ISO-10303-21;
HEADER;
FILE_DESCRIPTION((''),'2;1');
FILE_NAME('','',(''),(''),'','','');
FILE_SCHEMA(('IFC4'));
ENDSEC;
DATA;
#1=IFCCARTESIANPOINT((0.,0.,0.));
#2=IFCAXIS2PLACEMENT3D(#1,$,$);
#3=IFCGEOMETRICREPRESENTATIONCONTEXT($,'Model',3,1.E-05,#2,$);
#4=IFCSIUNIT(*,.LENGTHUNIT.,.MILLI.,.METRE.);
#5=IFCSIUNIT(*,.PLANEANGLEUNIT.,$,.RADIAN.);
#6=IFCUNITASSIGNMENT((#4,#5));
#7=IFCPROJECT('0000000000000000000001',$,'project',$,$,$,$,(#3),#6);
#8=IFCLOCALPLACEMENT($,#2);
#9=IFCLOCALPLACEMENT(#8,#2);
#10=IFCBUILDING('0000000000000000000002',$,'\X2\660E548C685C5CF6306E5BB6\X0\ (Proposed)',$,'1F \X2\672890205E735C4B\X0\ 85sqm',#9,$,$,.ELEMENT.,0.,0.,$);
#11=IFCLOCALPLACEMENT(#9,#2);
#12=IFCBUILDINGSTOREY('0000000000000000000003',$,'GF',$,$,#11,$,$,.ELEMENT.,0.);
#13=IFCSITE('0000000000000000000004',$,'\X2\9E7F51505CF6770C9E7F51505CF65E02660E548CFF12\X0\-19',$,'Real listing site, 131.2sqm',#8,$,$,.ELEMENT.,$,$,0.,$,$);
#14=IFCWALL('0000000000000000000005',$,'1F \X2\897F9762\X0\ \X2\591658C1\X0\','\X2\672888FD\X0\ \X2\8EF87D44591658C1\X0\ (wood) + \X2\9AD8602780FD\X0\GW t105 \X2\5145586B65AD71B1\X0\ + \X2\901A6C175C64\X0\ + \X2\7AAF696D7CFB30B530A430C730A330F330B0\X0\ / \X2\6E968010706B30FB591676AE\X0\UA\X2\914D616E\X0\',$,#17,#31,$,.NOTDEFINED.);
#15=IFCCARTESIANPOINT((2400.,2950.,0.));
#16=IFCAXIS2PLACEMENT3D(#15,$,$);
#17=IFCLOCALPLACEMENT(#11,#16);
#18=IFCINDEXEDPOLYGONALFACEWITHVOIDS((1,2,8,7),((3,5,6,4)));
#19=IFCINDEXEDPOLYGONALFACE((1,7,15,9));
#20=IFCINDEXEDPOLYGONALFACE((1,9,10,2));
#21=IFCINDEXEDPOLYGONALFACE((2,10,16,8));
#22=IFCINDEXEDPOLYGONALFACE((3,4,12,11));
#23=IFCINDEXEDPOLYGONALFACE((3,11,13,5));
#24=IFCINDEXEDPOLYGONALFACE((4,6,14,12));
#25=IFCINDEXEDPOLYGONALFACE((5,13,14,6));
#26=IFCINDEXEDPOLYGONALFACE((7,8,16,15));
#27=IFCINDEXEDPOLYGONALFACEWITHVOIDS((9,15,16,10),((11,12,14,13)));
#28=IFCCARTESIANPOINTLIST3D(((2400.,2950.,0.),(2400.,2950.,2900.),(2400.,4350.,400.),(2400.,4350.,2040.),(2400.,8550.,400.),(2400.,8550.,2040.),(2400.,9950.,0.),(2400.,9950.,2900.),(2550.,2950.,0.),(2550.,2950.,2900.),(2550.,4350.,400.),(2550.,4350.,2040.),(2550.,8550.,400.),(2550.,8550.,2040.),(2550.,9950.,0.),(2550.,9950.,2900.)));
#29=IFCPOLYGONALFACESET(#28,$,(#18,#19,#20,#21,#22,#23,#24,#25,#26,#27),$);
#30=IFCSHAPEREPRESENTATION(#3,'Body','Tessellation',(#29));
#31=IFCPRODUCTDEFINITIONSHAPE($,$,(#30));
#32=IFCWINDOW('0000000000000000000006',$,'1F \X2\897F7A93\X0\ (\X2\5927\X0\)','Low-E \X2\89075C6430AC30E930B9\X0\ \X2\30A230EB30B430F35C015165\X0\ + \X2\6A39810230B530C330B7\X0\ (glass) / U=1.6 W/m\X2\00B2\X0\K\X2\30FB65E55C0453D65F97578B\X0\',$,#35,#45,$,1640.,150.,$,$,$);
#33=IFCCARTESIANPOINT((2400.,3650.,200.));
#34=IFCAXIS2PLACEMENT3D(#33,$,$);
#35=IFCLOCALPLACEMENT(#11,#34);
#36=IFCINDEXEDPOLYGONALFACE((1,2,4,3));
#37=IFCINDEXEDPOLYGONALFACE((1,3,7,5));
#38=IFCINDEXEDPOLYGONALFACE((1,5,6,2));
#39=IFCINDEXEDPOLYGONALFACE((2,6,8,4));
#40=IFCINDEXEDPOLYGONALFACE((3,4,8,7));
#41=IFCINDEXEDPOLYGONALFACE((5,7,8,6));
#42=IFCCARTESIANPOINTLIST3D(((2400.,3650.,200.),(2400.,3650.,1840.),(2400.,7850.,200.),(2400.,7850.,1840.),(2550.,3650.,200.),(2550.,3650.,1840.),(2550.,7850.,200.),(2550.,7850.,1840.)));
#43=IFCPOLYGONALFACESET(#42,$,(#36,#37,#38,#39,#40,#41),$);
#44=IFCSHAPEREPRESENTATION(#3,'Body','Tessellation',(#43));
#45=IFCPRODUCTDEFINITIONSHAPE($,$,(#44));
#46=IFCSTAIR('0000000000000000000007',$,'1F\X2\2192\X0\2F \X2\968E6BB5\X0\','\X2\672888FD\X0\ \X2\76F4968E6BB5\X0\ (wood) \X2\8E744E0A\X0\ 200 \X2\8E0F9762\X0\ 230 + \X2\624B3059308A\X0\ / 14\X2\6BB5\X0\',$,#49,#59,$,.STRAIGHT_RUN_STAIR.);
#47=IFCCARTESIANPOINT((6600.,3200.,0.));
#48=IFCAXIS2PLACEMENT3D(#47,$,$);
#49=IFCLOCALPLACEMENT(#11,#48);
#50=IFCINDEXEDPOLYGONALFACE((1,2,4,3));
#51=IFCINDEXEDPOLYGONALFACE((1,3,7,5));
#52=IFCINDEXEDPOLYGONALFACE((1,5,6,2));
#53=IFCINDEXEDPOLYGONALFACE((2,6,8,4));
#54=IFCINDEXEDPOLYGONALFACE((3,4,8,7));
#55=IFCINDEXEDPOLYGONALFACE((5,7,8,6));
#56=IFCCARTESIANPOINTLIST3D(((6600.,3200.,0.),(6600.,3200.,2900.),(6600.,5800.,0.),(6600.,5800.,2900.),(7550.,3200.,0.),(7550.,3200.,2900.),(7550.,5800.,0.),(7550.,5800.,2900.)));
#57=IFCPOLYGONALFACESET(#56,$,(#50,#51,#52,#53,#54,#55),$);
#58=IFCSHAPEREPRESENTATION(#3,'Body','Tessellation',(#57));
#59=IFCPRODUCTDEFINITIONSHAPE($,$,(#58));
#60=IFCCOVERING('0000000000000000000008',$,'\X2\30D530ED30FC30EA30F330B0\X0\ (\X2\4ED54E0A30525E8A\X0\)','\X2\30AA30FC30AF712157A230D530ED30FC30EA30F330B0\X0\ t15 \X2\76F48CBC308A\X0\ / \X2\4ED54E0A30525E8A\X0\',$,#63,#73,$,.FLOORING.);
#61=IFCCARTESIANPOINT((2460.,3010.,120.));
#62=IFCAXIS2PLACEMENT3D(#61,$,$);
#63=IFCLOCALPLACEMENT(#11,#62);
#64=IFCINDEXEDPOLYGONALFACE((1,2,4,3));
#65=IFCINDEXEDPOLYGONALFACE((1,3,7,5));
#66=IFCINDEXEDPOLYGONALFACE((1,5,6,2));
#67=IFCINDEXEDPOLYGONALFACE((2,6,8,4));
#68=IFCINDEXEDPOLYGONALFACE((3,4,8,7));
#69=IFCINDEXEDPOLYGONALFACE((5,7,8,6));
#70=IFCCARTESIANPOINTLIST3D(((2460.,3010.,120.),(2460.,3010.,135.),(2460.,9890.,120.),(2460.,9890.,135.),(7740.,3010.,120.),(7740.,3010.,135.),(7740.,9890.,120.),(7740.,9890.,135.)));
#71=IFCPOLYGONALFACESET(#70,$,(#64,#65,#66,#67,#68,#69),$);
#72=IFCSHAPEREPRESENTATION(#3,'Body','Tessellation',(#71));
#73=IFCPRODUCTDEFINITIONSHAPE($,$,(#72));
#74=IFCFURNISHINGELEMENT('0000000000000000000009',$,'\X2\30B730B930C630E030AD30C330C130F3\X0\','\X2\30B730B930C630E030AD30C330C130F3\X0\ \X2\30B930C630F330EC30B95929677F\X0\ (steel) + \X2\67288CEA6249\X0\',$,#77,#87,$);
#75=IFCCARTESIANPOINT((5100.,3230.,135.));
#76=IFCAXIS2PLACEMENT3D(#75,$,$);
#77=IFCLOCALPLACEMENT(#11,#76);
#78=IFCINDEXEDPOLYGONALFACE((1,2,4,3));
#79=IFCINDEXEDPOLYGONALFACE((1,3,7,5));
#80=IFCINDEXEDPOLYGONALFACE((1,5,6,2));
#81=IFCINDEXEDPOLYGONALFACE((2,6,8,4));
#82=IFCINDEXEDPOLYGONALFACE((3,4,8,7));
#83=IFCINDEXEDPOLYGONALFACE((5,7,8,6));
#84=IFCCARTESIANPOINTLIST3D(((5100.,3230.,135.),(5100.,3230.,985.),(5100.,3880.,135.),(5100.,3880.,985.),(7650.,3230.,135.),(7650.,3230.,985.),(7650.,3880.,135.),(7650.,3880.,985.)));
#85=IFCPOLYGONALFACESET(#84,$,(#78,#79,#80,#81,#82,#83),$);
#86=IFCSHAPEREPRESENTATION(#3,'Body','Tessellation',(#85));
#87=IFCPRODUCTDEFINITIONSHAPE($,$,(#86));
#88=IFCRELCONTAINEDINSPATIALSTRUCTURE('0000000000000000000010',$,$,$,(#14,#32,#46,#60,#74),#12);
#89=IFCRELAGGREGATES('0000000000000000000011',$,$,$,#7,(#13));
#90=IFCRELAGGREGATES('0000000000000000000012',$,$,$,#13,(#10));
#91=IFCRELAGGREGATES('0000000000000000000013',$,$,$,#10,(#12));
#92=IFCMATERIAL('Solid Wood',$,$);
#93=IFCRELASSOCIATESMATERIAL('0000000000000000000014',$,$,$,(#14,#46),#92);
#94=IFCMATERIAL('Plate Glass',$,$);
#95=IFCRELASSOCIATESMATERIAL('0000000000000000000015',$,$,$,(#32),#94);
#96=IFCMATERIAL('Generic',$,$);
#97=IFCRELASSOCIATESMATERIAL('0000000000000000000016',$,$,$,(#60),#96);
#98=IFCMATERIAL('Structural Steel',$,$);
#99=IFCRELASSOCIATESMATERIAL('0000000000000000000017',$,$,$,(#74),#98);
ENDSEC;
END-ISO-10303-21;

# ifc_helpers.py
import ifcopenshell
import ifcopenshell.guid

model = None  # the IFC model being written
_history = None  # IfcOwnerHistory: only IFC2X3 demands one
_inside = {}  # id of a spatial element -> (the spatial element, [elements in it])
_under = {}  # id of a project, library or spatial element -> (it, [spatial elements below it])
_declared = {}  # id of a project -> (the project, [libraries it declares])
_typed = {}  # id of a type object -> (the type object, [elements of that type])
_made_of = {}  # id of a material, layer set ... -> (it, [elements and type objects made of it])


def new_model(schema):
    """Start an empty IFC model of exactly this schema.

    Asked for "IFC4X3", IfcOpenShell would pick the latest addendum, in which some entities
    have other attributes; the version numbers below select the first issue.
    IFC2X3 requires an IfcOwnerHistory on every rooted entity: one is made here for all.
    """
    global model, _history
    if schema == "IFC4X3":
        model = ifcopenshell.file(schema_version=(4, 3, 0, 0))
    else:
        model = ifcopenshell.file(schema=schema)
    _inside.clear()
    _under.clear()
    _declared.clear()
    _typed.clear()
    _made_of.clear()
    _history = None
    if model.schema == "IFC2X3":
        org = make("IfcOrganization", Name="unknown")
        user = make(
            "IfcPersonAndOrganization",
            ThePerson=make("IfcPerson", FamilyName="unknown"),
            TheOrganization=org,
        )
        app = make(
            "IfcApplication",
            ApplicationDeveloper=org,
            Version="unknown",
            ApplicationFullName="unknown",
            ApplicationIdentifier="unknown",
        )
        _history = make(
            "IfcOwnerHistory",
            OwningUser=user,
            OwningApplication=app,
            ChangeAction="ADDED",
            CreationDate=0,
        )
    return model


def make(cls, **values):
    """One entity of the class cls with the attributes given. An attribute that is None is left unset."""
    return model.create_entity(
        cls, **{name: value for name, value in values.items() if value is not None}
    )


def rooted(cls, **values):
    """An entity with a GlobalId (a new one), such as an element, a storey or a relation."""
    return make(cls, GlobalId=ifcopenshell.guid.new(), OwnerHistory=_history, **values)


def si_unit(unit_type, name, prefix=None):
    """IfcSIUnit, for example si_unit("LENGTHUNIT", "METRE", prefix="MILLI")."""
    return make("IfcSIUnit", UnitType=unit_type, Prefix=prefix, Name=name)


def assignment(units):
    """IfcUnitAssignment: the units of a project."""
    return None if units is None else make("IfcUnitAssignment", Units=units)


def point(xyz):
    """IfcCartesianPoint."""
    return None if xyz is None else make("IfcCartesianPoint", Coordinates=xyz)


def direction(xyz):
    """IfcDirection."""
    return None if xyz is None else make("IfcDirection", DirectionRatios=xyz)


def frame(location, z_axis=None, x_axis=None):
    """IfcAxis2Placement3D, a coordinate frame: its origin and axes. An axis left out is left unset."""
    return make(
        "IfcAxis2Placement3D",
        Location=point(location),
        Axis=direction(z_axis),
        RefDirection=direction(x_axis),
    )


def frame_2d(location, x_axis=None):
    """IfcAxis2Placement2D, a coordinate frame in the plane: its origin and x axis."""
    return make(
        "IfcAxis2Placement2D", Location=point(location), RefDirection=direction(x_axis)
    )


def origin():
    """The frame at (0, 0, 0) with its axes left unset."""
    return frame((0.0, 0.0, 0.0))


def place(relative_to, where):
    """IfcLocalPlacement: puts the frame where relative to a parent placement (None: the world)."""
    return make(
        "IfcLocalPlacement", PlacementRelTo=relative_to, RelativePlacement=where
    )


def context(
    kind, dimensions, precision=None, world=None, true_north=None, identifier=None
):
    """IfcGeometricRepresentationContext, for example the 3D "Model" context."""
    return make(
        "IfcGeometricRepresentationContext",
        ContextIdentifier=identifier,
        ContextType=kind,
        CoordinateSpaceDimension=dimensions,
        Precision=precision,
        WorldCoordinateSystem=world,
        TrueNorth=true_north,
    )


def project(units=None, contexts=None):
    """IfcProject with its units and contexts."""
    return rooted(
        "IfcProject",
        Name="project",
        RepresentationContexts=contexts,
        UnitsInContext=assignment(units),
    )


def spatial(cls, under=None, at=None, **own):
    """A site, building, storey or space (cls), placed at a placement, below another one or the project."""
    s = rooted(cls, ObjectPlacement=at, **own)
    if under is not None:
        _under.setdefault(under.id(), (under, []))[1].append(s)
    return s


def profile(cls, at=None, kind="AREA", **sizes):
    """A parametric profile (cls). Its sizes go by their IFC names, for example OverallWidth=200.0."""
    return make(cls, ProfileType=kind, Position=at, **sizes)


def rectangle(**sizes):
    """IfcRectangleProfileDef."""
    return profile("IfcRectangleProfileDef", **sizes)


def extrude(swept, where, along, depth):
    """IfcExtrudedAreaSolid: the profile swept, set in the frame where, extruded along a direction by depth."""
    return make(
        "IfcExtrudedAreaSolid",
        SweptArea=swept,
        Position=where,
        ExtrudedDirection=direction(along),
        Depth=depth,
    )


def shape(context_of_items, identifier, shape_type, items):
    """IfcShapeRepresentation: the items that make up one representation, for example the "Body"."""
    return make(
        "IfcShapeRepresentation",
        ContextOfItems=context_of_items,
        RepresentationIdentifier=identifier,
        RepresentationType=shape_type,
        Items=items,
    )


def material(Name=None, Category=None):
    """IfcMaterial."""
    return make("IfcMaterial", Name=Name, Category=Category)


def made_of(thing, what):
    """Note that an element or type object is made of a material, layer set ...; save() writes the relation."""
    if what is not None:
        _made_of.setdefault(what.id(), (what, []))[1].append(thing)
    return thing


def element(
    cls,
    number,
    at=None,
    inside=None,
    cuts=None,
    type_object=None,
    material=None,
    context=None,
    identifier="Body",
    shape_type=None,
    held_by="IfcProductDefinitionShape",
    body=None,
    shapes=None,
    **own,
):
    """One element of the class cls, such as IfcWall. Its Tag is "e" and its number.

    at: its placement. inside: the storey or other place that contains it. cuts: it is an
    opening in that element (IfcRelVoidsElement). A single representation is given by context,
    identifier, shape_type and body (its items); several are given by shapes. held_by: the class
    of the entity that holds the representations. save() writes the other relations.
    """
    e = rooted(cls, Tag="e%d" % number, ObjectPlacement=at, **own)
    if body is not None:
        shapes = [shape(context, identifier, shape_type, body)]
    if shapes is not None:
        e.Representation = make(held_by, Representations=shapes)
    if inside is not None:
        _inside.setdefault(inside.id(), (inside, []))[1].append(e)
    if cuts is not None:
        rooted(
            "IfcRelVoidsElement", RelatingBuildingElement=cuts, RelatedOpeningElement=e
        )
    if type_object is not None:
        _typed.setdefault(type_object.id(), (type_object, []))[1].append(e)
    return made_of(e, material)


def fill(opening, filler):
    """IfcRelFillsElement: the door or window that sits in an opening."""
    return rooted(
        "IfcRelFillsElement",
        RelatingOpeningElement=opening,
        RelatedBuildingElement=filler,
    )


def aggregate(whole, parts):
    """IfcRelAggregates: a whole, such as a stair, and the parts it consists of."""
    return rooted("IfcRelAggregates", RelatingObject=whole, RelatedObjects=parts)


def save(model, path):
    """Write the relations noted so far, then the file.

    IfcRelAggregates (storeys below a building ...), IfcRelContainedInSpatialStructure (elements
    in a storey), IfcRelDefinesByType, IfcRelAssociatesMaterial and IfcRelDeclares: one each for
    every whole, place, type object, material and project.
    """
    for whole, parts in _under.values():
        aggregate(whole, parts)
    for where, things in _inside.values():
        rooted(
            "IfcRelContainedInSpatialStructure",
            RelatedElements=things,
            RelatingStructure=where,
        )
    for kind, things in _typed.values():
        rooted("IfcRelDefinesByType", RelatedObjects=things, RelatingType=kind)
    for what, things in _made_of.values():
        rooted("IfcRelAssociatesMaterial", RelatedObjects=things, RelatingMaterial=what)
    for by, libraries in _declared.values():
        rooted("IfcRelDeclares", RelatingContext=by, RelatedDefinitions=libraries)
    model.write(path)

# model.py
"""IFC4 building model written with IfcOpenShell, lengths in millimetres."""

from ifc_helpers import new_model, si_unit, frame, frame_2d, origin, place, context, project, spatial, rectangle, extrude, material, element, fill, save


model = new_model("IFC4")

# Units and contexts
model_context = context("Model", 3, precision=1e-05, world=origin())
ifc_project = project(units=[si_unit("LENGTHUNIT", "METRE", prefix="MILLI"), si_unit("PLANEANGLEUNIT", "RADIAN")], contexts=[model_context])

# Site, building, storey
site_placement = place(None, origin())
site = spatial("IfcSite", under=ifc_project, at=site_placement, Name="鹿児島県鹿児島市明和２-19", ObjectType="Real listing site, 131.2sqm", CompositionType="ELEMENT", RefElevation=0.0)
building_placement = place(site_placement, origin())
building = spatial("IfcBuilding", under=site, at=building_placement, Name="明和桜島の家 (Proposed)", ObjectType="1F 木造平屋 85sqm", CompositionType="ELEMENT", ElevationOfRefHeight=0.0, ElevationOfTerrain=0.0)
storey_placement = place(building_placement, origin())
storey = spatial("IfcBuildingStorey", under=building, at=storey_placement, Name="GF", CompositionType="ELEMENT", Elevation=0.0)

# Shared definitions
ifc_material_1 = material(Name="Solid Wood")
ifc_material_2 = material(Name="Generic")

# Shared definitions
ifc_material_3 = material(Name="Plate Glass")

# Wall, opening, window
wall_1_placement = place(storey_placement, frame((2400.0, 2950.0, 0.0)))
wall_1 = element("IfcWall", 1, at=wall_1_placement, inside=storey, material=ifc_material_1, Name="1F 西面 外壁", Description="木製 軸組外壁 (wood) + 高性能GW t105 充填断熱 + 通気層 + 窯業系サイディング / 準耐火・外皮UA配慮", PredefinedType="NOTDEFINED", context=model_context, shape_type="SweptSolid", body=[
    extrude(rectangle(XDim=150.0, YDim=7000.0, at=frame_2d((75.0, 3500.0))), frame((2400.0, 2950.0, 0.0)), (0.0, 0.0, 1.0), 2900.0),
])
opening_1_placement = place(storey_placement, frame((2400.0, 3650.0, 200.0)))
opening_1 = element("IfcOpeningElement", 2, at=opening_1_placement, cuts=wall_1, PredefinedType="NOTDEFINED", context=model_context, shape_type="SweptSolid", body=[
    extrude(rectangle(XDim=150.0, YDim=4200.0, at=frame_2d((75.0, 2100.0))), frame((2400.0, 3650.0, 200.0)), (0.0, 0.0, 1.0), 1640.0),
])
window_1_placement = place(storey_placement, frame((2400.0, 3650.0, 200.0)))
window_1 = element("IfcWindow", 3, at=window_1_placement, inside=storey, material=ifc_material_3, Name="1F 西窓 (大)", Description="Low-E 複層ガラス アルゴン封入 + 樹脂サッシ (glass) / U=1.6 W/m²K・日射取得型", OverallHeight=1640.0, OverallWidth=150.0, context=model_context, shape_type="SweptSolid", body=[
    extrude(rectangle(XDim=150.0, YDim=4200.0, at=frame_2d((75.0, 2100.0))), frame((2400.0, 3650.0, 200.0)), (0.0, 0.0, 1.0), 1640.0),
])
fill(opening_1, window_1)

# Stair
stair_placement = place(storey_placement, frame((6600.0, 3200.0, 0.0)))
element("IfcStair", 4, at=stair_placement, inside=storey, material=ifc_material_1, Name="1F→2F 階段", Description="木製 直階段 (wood) 蹴上 200 踏面 230 + 手すり / 14段", PredefinedType="STRAIGHT_RUN_STAIR", context=model_context, shape_type="SweptSolid", body=[
    extrude(rectangle(XDim=950.0, YDim=2600.0, at=frame_2d((475.0, 1300.0))), frame((6600.0, 3200.0, 0.0)), (0.0, 0.0, 1.0), 2900.0),
])

# Covering
covering_placement = place(storey_placement, frame((2460.0, 3010.0, 120.0)))
element("IfcCovering", 5, at=covering_placement, inside=storey, material=ifc_material_2, Name="フローリング (仕上げ床)", Description="オーク無垢フローリング t15 直貼り / 仕上げ床", PredefinedType="FLOORING", context=model_context, shape_type="SweptSolid", body=[
    extrude(rectangle(XDim=5280.0, YDim=6880.0, at=frame_2d((2640.0, 3440.0))), frame((2460.0, 3010.0, 120.0)), (0.0, 0.0, 1.0), 15.0),
])

# Furnishing element
ifc_material_4 = material(Name="Structural Steel")
furnishing_placement = place(storey_placement, frame((5100.0, 3230.0, 135.0)))
element("IfcFurnishingElement", 6, at=furnishing_placement, inside=storey, material=ifc_material_4, Name="システムキッチン", Description="システムキッチン ステンレス天板 (steel) + 木質扉", context=model_context, shape_type="SweptSolid", body=[
    extrude(rectangle(XDim=2550.0, YDim=650.0, at=frame_2d((1275.0, 325.0))), frame((5100.0, 3230.0, 135.0)), (0.0, 0.0, 1.0), 850.0),
])

save(model, "model.ifc")
